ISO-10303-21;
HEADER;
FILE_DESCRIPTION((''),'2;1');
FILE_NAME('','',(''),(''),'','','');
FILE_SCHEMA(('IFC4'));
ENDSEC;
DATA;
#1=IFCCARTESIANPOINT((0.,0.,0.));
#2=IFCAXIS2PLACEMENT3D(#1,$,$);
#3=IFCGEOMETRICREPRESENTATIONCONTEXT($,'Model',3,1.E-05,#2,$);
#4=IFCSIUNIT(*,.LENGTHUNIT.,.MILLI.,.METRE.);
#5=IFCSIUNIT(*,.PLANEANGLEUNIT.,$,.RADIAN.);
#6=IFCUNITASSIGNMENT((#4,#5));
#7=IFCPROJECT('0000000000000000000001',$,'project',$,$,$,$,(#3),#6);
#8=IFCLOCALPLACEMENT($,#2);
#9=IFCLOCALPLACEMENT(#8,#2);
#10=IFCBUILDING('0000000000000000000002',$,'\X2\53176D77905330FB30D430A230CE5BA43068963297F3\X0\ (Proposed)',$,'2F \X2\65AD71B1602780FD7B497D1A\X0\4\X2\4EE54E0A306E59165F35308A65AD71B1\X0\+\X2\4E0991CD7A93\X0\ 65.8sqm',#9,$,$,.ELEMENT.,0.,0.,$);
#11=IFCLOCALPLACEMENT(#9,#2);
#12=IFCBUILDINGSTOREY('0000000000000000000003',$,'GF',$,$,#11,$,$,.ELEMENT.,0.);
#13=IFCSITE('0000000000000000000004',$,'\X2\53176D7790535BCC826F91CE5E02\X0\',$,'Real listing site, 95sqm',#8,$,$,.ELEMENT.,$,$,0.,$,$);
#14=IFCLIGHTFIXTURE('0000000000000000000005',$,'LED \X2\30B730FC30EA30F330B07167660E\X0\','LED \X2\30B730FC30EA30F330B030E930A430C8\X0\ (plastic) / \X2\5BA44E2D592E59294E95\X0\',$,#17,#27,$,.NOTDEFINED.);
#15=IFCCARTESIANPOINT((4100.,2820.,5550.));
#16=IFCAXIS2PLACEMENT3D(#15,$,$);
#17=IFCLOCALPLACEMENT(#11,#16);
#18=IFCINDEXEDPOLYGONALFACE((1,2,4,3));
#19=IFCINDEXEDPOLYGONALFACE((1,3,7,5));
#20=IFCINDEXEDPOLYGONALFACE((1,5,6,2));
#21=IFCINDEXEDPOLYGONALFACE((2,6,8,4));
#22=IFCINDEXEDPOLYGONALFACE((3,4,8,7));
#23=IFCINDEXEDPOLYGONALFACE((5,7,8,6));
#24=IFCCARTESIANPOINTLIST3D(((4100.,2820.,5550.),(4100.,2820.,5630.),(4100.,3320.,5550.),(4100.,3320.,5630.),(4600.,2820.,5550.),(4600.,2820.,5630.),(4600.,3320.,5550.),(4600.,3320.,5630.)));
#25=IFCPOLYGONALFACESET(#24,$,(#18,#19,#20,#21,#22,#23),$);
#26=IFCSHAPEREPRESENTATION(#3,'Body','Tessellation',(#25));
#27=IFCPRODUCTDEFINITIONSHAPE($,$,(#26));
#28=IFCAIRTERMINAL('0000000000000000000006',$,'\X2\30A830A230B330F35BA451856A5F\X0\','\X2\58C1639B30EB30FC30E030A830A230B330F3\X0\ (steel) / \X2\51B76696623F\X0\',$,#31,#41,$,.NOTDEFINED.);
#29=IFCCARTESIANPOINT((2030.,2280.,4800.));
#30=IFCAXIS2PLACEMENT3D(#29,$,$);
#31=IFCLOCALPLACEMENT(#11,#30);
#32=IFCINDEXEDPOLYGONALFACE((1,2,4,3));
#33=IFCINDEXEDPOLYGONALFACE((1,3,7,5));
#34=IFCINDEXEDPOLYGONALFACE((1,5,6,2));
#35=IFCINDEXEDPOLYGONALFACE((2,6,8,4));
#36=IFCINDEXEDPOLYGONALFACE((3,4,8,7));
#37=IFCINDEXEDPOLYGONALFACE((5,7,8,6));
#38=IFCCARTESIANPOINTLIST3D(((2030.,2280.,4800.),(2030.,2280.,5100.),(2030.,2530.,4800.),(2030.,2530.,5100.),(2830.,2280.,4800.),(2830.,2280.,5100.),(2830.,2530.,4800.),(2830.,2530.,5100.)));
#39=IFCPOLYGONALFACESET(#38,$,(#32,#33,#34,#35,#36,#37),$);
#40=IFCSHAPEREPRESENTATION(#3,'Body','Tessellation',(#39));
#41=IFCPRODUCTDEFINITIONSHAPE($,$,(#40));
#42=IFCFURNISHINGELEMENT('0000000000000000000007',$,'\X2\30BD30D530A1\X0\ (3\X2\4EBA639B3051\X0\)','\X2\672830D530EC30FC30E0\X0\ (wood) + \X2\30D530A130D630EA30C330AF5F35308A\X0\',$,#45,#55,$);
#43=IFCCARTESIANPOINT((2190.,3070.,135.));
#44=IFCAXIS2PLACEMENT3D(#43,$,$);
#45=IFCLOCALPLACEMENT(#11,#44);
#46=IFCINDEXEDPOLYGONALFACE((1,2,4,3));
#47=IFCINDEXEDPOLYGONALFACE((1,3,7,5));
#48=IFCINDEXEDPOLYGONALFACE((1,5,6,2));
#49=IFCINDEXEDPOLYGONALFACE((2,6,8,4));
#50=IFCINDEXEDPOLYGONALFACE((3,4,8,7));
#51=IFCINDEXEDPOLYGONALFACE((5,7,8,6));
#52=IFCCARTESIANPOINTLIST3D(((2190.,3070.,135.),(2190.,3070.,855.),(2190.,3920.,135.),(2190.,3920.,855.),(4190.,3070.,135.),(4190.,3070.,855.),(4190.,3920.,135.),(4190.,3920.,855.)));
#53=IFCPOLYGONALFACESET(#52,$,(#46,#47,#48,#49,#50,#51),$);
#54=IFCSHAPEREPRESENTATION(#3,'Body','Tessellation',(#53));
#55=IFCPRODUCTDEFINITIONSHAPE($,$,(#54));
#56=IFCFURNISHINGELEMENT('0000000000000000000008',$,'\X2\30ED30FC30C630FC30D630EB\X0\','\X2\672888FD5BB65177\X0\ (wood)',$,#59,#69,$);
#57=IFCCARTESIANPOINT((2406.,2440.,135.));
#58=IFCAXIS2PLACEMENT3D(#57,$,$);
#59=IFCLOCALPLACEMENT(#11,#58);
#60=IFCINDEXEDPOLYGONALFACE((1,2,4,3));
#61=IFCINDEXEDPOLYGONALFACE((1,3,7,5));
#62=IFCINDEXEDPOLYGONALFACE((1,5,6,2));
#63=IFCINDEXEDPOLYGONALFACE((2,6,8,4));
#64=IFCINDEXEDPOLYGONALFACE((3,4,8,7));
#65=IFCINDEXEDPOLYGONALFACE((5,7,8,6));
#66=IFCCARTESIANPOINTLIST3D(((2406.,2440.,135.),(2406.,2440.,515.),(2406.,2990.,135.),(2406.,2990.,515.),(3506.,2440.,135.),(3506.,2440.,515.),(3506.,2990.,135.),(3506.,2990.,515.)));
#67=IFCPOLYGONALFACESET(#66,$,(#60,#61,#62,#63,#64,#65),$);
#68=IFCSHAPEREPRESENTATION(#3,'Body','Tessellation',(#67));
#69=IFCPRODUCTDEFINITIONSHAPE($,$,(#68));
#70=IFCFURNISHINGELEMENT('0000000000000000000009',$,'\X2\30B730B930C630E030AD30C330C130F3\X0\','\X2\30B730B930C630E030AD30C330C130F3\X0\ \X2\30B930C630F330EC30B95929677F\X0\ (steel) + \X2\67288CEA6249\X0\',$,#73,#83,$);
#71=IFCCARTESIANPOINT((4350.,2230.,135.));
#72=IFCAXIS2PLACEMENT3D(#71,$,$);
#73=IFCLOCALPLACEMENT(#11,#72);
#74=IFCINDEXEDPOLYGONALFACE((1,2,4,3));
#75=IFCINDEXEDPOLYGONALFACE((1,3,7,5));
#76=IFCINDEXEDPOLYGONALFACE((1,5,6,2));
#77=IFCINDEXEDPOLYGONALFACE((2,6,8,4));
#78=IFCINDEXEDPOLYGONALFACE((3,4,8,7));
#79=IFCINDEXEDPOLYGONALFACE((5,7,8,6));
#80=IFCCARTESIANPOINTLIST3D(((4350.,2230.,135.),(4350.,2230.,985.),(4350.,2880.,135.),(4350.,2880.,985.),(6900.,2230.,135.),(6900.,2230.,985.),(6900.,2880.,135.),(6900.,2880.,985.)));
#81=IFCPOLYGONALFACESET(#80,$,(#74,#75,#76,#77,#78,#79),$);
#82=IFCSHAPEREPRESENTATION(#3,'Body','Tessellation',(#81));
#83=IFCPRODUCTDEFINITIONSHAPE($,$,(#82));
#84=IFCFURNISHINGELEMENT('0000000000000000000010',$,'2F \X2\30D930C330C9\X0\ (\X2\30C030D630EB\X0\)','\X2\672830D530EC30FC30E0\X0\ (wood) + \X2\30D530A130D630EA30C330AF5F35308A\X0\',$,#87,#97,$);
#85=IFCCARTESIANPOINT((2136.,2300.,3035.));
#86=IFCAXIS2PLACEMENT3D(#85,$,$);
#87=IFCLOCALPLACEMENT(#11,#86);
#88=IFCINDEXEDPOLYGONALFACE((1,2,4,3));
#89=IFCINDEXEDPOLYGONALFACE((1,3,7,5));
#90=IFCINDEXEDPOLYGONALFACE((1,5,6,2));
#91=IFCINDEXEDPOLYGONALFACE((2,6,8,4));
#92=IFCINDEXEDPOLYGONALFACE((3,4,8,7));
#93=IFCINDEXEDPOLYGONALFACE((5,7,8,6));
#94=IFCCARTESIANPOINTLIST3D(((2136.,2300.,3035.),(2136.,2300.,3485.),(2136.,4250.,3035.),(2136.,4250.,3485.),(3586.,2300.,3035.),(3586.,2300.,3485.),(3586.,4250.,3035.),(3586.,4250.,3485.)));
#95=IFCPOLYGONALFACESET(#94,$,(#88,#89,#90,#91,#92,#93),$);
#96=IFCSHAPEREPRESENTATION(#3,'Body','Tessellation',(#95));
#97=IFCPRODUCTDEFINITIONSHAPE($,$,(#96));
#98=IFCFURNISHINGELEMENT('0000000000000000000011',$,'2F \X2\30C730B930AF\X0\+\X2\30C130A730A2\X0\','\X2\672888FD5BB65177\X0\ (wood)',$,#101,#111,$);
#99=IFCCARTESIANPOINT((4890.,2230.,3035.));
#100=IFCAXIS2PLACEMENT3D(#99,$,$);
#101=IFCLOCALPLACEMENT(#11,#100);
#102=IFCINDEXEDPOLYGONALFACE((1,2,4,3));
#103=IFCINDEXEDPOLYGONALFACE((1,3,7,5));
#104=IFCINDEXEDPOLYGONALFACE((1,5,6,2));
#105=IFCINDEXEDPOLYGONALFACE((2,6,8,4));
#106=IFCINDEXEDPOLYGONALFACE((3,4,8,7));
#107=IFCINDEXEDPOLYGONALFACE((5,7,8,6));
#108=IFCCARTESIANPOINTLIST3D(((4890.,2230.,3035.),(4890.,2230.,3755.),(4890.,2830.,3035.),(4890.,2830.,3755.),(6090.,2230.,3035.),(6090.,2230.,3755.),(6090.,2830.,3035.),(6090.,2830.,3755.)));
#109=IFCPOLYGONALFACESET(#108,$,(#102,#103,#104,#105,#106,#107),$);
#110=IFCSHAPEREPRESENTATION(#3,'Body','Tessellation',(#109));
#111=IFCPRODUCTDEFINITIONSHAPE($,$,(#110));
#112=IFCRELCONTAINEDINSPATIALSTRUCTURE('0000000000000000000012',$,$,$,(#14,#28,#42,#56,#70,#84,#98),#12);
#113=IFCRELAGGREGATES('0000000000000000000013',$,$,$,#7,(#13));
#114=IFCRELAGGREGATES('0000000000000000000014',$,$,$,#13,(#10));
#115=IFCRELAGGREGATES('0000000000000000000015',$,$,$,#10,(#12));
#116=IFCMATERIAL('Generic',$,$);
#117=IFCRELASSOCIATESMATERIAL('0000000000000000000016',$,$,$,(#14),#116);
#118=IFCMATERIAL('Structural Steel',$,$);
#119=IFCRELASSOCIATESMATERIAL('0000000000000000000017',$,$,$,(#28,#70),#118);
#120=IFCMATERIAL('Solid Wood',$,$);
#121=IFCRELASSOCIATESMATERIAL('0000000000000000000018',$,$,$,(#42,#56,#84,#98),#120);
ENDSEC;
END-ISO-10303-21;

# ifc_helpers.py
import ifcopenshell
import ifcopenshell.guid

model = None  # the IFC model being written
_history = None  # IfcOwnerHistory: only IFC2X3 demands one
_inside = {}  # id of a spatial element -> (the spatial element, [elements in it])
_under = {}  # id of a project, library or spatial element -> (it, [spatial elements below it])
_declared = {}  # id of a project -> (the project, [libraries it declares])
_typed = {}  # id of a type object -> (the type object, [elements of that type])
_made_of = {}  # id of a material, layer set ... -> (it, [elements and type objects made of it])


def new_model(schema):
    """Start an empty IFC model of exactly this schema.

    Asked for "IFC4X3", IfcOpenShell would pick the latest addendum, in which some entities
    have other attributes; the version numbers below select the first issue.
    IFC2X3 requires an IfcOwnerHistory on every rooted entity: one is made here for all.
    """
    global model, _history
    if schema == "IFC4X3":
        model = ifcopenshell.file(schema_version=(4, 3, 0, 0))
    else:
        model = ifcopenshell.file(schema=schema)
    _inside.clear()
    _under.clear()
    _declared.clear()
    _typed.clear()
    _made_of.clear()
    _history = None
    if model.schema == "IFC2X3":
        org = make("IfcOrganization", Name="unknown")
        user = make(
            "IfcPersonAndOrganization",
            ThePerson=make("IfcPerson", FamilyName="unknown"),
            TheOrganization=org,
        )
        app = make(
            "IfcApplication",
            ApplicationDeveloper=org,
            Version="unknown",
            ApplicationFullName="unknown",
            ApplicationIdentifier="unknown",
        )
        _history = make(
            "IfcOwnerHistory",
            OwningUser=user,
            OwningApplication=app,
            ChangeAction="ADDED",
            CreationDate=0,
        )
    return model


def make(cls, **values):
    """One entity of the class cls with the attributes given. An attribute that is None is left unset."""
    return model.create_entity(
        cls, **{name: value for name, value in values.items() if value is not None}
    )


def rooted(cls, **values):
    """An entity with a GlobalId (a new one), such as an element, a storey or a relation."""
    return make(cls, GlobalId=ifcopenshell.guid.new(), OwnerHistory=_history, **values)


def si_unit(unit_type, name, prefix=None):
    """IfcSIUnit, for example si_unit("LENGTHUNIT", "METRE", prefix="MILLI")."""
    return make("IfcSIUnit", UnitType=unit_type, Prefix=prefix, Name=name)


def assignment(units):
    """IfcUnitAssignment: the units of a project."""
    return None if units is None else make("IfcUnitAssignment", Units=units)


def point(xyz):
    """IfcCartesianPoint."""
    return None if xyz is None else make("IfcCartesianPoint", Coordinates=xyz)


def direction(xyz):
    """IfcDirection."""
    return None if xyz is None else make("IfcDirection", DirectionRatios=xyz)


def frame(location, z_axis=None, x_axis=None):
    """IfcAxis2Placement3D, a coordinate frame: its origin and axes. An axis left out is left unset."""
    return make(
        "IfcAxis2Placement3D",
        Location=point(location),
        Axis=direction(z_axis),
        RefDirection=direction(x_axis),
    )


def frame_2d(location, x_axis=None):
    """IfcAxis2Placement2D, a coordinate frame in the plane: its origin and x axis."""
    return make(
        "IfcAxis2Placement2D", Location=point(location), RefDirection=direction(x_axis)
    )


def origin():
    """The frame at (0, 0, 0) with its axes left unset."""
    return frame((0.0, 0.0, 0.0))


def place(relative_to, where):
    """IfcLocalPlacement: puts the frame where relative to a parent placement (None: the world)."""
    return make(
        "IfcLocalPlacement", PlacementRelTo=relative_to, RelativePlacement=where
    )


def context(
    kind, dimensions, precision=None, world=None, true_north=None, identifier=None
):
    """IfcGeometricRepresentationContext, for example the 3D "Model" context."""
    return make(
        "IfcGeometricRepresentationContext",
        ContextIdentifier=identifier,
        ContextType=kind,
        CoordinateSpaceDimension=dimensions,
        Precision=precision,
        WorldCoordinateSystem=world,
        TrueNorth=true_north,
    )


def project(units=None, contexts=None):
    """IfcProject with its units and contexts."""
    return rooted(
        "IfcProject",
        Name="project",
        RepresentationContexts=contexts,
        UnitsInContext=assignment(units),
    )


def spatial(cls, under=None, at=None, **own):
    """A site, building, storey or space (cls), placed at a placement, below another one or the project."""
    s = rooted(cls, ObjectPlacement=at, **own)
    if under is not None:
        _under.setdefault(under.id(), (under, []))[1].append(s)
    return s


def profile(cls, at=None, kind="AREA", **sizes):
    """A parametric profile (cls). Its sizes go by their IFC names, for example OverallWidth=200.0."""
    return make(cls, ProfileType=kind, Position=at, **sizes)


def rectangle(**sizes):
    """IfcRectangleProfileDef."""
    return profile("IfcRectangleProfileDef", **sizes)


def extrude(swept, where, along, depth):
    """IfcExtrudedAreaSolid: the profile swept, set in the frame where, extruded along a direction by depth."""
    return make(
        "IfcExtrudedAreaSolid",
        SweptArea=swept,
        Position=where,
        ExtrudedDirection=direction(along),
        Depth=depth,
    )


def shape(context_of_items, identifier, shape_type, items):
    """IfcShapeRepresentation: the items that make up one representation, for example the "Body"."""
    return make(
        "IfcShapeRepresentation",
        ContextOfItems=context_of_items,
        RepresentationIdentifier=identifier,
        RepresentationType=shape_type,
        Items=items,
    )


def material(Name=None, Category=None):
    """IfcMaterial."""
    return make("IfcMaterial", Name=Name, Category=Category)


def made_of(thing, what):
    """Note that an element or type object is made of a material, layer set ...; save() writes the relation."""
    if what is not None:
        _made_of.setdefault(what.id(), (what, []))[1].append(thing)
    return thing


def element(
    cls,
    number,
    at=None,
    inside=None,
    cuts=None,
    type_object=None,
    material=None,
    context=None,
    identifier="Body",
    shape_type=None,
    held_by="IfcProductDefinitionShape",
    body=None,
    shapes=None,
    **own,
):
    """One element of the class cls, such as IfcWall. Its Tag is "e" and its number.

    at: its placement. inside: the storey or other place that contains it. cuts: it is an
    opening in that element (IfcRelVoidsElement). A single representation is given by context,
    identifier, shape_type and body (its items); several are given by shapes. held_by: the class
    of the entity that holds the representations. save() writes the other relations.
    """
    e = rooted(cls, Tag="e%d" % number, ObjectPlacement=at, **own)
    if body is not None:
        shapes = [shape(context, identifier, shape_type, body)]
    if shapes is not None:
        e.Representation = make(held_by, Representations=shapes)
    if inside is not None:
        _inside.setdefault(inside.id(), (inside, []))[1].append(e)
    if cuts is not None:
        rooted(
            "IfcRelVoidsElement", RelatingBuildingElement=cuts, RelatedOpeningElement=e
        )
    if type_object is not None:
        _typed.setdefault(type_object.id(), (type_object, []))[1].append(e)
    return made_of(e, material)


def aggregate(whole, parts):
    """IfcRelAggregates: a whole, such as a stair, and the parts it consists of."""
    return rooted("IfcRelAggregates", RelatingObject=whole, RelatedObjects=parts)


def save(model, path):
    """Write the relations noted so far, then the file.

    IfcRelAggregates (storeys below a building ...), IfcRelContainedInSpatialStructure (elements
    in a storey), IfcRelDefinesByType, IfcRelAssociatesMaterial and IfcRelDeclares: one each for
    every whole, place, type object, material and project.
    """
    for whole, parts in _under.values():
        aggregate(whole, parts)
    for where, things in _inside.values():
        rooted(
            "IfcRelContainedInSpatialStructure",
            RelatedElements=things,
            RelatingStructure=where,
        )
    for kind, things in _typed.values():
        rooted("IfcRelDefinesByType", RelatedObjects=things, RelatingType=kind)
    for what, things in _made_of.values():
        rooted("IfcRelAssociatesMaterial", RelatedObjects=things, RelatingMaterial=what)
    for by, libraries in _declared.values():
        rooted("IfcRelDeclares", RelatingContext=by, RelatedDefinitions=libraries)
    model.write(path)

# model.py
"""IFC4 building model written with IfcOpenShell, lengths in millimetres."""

from ifc_helpers import new_model, si_unit, frame, frame_2d, origin, place, context, project, spatial, rectangle, extrude, material, element, save


model = new_model("IFC4")

# Units and contexts
model_context = context("Model", 3, precision=1e-05, world=origin())
ifc_project = project(units=[si_unit("LENGTHUNIT", "METRE", prefix="MILLI"), si_unit("PLANEANGLEUNIT", "RADIAN")], contexts=[model_context])

# Site, building, storey
site_placement = place(None, origin())
site = spatial("IfcSite", under=ifc_project, at=site_placement, Name="北海道富良野市", ObjectType="Real listing site, 95sqm", CompositionType="ELEMENT", RefElevation=0.0)
building_placement = place(site_placement, origin())
building = spatial("IfcBuilding", under=site, at=building_placement, Name="北海道・ピアノ室と防音 (Proposed)", ObjectType="2F 断熱性能等級4以上の外張り断熱+三重窓 65.8sqm", CompositionType="ELEMENT", ElevationOfRefHeight=0.0, ElevationOfTerrain=0.0)
storey_placement = place(building_placement, origin())
storey = spatial("IfcBuildingStorey", under=building, at=storey_placement, Name="GF", CompositionType="ELEMENT", Elevation=0.0)

# Shared definitions
ifc_material_1 = material(Name="Solid Wood")

# Shared definitions
ifc_material_2 = material(Name="Generic")

# Shared definitions
ifc_material_3 = material(Name="Structural Steel")

# Light fixture
light_fixture_1_placement = place(storey_placement, frame((4100.0, 2820.0, 5550.0)))
element("IfcLightFixture", 1, at=light_fixture_1_placement, inside=storey, material=ifc_material_2, Name="LED シーリング照明", Description="LED シーリングライト (plastic) / 室中央天井", PredefinedType="NOTDEFINED", context=model_context, shape_type="SweptSolid", body=[
    extrude(rectangle(XDim=500.0, YDim=500.0, at=frame_2d((250.0, 250.0))), frame((4100.0, 2820.0, 5550.0)), (0.0, 0.0, 1.0), 80.0),
])

# Air terminal
air_terminal_placement = place(storey_placement, frame((2030.0, 2280.0, 4800.0)))
element("IfcAirTerminal", 2, at=air_terminal_placement, inside=storey, material=ifc_material_3, Name="エアコン室内機", Description="壁掛ルームエアコン (steel) / 冷暖房", PredefinedType="NOTDEFINED", context=model_context, shape_type="SweptSolid", body=[
    extrude(rectangle(XDim=800.0, YDim=250.0, at=frame_2d((400.0, 125.0))), frame((2030.0, 2280.0, 4800.0)), (0.0, 0.0, 1.0), 300.0),
])

# Furnishing elements
furnishing_1_placement = place(storey_placement, frame((2190.0, 3070.0, 135.0)))
element("IfcFurnishingElement", 3, at=furnishing_1_placement, inside=storey, material=ifc_material_1, Name="ソファ (3人掛け)", Description="木フレーム (wood) + ファブリック張り", context=model_context, shape_type="SweptSolid", body=[
    extrude(rectangle(XDim=2000.0, YDim=850.0, at=frame_2d((1000.0, 425.0))), frame((2190.0, 3070.0, 135.0)), (0.0, 0.0, 1.0), 720.0),
])
furnishing_2_placement = place(storey_placement, frame((2406.0, 2440.0, 135.0)))
element("IfcFurnishingElement", 4, at=furnishing_2_placement, inside=storey, material=ifc_material_1, Name="ローテーブル", Description="木製家具 (wood)", context=model_context, shape_type="SweptSolid", body=[
    extrude(rectangle(XDim=1100.0, YDim=550.0, at=frame_2d((550.0, 275.0))), frame((2406.0, 2440.0, 135.0)), (0.0, 0.0, 1.0), 380.0),
])
furnishing_3_placement = place(storey_placement, frame((4350.0, 2230.0, 135.0)))
element("IfcFurnishingElement", 5, at=furnishing_3_placement, inside=storey, material=ifc_material_3, Name="システムキッチン", Description="システムキッチン ステンレス天板 (steel) + 木質扉", context=model_context, shape_type="SweptSolid", body=[
    extrude(rectangle(XDim=2550.0, YDim=650.0, at=frame_2d((1275.0, 325.0))), frame((4350.0, 2230.0, 135.0)), (0.0, 0.0, 1.0), 850.0),
])
furnishing_4_placement = place(storey_placement, frame((2136.0, 2300.0, 3035.0)))
element("IfcFurnishingElement", 6, at=furnishing_4_placement, inside=storey, material=ifc_material_1, Name="2F ベッド (ダブル)", Description="木フレーム (wood) + ファブリック張り", context=model_context, shape_type="SweptSolid", body=[
    extrude(rectangle(XDim=1450.0, YDim=1950.0, at=frame_2d((725.0, 975.0))), frame((2136.0, 2300.0, 3035.0)), (0.0, 0.0, 1.0), 450.0),
])
furnishing_5_placement = place(storey_placement, frame((4890.0, 2230.0, 3035.0)))
element("IfcFurnishingElement", 7, at=furnishing_5_placement, inside=storey, material=ifc_material_1, Name="2F デスク+チェア", Description="木製家具 (wood)", context=model_context, shape_type="SweptSolid", body=[
    extrude(rectangle(XDim=1200.0, YDim=600.0, at=frame_2d((600.0, 300.0))), frame((4890.0, 2230.0, 3035.0)), (0.0, 0.0, 1.0), 720.0),
])

save(model, "model.ifc")
